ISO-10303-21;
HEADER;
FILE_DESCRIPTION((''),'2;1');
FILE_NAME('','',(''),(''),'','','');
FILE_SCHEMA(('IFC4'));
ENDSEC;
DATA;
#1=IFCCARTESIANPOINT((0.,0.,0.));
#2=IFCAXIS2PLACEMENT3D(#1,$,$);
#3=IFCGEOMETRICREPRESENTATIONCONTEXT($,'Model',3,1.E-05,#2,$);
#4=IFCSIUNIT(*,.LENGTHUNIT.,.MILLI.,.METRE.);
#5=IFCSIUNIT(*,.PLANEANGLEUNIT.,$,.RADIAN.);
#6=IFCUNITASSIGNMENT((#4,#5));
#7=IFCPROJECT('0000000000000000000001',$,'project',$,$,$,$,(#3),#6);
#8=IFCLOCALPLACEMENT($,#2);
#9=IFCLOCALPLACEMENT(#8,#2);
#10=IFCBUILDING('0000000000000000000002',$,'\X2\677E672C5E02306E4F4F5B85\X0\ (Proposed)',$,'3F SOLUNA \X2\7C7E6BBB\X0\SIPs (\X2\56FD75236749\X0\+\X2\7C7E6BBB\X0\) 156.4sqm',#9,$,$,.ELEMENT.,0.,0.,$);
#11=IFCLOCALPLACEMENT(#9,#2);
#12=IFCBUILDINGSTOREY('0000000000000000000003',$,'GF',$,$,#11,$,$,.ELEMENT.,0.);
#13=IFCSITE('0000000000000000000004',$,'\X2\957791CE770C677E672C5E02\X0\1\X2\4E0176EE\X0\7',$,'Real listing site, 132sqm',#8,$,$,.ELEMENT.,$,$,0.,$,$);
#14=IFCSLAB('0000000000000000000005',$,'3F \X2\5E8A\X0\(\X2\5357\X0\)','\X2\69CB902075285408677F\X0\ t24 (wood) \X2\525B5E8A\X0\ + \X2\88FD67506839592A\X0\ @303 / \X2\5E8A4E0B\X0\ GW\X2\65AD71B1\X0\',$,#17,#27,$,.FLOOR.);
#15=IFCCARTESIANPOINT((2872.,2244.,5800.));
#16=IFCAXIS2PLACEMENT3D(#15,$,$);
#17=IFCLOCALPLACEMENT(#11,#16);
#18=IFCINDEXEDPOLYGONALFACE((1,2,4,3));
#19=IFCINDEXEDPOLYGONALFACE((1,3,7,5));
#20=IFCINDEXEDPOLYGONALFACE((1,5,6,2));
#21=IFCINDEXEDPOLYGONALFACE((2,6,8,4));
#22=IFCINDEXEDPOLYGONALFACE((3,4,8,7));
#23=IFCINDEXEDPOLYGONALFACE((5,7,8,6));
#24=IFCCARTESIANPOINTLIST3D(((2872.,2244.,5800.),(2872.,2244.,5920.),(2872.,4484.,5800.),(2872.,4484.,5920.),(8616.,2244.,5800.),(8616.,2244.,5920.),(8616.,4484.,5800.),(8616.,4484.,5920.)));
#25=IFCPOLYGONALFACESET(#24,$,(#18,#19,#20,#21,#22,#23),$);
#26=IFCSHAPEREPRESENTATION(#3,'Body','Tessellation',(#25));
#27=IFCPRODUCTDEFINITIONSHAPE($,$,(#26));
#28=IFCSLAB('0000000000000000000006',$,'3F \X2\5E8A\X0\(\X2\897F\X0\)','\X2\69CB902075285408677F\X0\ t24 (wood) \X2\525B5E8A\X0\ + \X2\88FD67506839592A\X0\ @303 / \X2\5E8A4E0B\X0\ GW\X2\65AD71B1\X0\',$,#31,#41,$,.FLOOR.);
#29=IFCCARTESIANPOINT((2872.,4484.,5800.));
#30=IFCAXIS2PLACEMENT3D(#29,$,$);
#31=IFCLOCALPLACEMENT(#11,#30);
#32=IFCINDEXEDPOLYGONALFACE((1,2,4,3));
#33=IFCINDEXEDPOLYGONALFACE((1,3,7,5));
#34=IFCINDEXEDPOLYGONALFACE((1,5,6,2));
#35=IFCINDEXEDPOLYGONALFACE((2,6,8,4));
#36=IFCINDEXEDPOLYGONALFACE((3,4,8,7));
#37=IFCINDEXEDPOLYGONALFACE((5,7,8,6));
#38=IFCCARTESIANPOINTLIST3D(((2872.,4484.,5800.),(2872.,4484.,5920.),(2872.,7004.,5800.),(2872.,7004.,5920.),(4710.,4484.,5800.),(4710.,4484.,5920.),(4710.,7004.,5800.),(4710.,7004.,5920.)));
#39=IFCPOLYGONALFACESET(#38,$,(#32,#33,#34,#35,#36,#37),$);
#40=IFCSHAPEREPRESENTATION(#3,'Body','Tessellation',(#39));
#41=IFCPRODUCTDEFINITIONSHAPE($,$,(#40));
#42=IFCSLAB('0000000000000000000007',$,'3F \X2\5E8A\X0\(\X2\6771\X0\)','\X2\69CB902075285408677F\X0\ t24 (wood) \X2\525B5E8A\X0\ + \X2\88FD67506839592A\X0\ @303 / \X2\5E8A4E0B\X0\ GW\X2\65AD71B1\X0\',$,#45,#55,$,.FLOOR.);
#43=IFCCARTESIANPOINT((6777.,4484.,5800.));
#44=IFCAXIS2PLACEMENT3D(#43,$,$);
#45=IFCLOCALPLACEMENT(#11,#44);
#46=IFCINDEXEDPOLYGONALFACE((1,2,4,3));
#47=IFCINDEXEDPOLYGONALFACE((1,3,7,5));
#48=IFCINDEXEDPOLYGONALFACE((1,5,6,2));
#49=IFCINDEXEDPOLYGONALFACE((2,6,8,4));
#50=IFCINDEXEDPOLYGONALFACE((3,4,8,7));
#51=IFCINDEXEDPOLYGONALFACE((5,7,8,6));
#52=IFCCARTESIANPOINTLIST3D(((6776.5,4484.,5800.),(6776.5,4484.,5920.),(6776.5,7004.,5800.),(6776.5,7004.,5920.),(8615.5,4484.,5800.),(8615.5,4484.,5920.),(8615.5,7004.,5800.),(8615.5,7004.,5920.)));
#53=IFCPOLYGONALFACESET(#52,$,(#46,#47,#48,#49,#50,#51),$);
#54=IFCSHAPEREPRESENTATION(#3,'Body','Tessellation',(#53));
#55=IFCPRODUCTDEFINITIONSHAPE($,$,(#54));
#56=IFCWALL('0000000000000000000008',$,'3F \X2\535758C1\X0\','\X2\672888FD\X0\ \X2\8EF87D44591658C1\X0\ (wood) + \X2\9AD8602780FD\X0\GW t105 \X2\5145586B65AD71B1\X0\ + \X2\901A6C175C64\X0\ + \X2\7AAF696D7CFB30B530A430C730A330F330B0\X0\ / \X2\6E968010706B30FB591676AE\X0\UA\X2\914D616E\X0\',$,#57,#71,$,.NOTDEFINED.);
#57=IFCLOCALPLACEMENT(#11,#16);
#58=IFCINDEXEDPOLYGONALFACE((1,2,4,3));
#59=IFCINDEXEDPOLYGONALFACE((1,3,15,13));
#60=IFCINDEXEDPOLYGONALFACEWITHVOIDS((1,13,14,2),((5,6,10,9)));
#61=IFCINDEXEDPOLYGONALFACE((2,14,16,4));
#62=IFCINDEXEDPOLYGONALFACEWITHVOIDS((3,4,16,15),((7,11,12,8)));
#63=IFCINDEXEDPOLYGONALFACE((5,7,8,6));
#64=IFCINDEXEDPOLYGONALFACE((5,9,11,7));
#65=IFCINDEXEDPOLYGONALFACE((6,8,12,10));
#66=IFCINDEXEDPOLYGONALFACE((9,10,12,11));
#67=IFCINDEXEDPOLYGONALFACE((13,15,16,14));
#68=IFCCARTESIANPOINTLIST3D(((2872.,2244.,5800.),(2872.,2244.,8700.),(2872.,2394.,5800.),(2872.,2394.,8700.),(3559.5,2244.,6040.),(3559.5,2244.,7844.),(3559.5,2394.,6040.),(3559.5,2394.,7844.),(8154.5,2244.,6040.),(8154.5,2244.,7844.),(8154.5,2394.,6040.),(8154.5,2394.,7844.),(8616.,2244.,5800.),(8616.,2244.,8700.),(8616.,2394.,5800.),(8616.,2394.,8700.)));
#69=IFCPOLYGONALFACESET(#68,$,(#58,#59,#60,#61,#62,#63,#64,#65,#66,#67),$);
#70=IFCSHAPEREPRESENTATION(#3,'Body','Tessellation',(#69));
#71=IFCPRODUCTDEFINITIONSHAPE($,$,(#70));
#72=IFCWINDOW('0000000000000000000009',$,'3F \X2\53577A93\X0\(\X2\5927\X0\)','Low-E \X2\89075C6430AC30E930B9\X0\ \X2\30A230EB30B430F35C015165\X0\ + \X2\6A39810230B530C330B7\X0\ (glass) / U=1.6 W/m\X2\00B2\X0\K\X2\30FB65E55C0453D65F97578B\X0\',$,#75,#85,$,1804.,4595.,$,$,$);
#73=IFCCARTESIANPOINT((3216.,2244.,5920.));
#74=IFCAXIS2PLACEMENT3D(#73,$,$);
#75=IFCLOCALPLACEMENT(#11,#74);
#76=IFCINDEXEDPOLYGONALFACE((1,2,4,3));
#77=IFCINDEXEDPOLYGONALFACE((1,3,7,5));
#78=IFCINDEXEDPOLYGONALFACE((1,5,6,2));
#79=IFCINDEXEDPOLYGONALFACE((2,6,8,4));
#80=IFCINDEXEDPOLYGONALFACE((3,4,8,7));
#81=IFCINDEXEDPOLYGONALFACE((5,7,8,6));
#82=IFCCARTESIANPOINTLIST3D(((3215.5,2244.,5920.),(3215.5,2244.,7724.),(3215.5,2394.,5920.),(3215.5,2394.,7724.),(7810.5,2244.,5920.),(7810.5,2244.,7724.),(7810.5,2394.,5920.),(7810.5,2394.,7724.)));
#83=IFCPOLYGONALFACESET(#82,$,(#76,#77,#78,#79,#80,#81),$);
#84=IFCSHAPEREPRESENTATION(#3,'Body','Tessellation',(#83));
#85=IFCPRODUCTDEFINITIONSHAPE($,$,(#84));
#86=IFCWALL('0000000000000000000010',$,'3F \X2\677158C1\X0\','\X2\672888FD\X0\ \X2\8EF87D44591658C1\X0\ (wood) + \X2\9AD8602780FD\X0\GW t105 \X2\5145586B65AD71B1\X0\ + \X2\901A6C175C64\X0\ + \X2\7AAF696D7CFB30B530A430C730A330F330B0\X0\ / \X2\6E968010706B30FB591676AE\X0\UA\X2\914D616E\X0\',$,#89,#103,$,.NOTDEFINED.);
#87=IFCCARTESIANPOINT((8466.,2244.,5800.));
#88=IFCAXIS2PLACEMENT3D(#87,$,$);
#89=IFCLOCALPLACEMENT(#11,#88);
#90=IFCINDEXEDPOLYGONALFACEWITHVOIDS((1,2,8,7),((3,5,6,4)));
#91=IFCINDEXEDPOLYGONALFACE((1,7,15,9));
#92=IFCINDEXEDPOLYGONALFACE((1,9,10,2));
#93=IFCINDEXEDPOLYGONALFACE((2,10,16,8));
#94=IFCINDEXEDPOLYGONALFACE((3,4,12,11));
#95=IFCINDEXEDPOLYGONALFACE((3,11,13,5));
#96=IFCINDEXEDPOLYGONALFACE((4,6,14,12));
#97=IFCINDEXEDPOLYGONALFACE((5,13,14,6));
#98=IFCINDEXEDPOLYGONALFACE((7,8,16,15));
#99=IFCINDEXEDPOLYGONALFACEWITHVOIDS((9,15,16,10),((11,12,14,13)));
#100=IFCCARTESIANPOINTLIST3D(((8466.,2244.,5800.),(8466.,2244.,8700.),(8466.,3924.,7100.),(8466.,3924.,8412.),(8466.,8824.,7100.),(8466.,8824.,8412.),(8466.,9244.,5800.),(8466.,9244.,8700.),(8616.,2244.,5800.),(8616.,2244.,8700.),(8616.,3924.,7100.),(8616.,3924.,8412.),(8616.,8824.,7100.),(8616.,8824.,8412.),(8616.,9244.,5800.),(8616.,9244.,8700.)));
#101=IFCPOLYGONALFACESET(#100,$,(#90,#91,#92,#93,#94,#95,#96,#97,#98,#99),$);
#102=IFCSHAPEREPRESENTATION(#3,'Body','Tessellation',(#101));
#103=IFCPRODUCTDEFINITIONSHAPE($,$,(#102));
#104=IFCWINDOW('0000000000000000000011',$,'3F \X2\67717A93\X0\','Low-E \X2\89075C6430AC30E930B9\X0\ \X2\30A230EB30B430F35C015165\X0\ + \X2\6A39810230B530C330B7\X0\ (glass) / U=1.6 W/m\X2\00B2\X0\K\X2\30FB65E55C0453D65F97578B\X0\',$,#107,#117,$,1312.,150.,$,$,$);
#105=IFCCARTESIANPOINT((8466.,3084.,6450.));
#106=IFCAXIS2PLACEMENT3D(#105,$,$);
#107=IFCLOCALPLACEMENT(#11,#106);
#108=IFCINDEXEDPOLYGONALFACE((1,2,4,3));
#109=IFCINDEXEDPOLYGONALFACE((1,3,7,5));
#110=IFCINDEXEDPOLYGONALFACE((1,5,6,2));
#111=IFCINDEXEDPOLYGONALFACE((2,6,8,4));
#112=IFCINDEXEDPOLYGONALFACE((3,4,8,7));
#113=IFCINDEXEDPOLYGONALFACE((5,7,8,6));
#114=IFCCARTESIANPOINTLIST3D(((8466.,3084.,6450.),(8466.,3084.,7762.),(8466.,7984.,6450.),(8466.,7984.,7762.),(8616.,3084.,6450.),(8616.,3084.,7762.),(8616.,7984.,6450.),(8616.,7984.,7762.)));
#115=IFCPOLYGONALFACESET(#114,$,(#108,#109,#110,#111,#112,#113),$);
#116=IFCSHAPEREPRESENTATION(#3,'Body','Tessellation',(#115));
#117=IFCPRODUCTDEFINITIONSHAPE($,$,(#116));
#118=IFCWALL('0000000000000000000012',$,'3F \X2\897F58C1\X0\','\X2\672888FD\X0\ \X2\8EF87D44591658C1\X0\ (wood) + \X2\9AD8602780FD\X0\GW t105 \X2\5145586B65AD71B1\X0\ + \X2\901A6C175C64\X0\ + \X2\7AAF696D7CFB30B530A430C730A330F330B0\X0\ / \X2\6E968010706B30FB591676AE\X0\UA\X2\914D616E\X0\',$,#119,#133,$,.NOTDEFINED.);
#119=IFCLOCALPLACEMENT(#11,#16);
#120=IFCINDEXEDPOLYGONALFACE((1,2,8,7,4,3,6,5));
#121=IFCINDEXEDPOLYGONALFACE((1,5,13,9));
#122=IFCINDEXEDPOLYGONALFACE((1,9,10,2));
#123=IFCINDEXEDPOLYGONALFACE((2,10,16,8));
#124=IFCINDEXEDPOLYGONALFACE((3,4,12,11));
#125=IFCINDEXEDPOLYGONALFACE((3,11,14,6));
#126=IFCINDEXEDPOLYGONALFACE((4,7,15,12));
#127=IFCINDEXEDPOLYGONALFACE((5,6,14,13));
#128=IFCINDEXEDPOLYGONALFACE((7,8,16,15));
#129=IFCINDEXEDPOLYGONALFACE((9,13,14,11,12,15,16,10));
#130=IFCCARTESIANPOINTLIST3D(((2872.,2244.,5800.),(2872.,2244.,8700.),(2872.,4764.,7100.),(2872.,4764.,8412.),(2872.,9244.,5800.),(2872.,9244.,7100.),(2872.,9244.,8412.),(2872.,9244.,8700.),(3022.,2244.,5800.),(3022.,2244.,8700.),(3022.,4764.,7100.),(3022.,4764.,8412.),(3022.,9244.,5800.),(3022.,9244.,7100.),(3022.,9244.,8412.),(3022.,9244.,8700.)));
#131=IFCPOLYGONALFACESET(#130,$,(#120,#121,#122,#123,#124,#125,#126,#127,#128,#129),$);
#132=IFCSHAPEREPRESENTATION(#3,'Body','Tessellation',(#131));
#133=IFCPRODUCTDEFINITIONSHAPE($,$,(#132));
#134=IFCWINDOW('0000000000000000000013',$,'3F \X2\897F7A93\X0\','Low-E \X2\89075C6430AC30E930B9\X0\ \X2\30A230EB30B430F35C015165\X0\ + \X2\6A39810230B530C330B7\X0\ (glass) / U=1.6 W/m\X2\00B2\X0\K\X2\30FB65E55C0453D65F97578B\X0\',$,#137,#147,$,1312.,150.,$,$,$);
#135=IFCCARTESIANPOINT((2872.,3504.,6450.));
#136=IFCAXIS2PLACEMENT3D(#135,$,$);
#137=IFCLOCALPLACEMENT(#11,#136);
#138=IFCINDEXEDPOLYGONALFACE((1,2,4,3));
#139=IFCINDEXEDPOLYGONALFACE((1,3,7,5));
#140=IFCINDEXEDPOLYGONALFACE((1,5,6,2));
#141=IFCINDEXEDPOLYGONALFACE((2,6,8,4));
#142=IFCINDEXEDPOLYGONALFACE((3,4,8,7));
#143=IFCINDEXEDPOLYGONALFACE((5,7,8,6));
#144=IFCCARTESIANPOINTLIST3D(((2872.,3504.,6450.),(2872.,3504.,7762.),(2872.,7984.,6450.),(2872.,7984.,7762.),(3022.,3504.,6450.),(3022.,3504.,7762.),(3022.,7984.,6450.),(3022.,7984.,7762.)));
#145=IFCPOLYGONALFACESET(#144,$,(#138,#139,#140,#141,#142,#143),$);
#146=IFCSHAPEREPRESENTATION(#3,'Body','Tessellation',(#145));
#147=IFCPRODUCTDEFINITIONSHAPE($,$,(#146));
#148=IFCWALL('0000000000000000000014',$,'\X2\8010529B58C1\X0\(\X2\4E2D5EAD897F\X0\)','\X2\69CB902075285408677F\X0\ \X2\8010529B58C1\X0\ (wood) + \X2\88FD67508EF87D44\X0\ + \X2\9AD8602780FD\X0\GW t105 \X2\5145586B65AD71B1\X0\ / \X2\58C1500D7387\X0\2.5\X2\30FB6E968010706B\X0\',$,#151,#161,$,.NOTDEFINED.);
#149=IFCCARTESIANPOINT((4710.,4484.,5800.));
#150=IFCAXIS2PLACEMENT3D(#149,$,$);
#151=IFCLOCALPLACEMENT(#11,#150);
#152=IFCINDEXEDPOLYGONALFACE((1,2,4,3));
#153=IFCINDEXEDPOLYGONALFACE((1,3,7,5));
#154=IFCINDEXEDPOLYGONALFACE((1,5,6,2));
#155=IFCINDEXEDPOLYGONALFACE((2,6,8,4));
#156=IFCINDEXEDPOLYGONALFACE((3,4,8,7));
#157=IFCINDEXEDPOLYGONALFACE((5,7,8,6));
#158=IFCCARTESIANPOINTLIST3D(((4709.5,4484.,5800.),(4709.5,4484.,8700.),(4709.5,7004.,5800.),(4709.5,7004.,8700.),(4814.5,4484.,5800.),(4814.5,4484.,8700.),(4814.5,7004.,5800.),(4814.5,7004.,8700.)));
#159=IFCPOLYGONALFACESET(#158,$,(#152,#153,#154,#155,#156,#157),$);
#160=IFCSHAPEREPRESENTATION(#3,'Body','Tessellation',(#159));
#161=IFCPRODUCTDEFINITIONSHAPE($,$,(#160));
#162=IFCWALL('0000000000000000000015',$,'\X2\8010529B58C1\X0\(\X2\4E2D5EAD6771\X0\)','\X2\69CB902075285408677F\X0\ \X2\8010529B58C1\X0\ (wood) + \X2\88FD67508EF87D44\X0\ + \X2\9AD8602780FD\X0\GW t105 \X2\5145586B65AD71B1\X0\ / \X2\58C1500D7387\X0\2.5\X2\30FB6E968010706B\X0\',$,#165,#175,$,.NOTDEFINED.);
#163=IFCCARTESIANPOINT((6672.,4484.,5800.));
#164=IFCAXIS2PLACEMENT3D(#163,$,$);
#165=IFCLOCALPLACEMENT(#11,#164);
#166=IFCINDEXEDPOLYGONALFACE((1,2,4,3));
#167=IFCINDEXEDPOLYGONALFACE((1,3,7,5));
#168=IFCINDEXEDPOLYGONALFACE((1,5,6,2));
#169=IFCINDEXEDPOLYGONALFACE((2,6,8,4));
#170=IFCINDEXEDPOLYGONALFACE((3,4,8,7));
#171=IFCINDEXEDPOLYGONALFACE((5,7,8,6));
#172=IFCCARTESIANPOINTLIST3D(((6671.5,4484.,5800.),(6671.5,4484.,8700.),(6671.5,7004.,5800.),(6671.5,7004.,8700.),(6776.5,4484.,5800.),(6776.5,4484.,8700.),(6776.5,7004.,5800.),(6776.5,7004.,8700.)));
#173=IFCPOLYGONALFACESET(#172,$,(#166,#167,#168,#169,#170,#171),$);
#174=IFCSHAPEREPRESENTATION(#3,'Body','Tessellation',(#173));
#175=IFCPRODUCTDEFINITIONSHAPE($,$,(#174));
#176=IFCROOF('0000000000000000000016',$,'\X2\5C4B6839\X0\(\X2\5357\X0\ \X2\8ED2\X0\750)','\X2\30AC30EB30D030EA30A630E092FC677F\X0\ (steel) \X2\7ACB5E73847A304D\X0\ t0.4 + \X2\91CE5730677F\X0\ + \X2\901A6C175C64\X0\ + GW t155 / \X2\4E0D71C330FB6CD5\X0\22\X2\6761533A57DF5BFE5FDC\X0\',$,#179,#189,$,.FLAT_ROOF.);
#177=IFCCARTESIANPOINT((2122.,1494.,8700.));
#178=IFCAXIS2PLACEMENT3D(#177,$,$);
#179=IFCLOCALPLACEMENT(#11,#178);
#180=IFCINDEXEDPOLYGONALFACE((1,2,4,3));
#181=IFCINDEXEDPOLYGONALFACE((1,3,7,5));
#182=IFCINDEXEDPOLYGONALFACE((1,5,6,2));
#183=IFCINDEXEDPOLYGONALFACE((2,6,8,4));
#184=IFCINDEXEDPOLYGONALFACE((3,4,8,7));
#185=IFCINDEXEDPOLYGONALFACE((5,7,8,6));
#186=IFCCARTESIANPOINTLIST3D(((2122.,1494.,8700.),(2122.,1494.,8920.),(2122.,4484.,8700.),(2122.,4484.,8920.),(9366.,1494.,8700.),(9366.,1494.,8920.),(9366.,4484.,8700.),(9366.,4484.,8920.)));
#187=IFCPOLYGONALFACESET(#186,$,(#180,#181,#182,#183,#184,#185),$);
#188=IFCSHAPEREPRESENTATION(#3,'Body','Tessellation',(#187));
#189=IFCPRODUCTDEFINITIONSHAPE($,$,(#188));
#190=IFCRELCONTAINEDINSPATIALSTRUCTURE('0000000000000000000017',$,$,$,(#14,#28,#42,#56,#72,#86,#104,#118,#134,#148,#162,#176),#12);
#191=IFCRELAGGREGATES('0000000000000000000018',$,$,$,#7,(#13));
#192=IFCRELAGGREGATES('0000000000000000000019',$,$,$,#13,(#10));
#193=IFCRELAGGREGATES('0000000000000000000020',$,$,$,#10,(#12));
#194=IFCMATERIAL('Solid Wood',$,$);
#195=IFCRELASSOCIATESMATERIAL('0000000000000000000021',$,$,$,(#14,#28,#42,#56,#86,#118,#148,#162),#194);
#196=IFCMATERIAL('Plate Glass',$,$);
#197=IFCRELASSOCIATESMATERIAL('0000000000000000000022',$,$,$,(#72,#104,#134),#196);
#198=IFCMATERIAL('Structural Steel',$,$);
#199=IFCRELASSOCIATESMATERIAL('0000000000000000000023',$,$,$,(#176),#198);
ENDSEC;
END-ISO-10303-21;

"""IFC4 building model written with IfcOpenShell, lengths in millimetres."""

from ifc_helpers import new_model, si_unit, frame, frame_2d, origin, place, context, project, spatial, rectangle, extrude, material, element, fill, save


model = new_model("IFC4")

# Units and contexts
model_context = context("Model", 3, precision=1e-05, world=origin())
ifc_project = project(units=[si_unit("LENGTHUNIT", "METRE", prefix="MILLI"), si_unit("PLANEANGLEUNIT", "RADIAN")], contexts=[model_context])

# Site, building, storey
site_placement = place(None, origin())
site = spatial("IfcSite", under=ifc_project, at=site_placement, Name="長野県松本市1丁目7", ObjectType="Real listing site, 132sqm", CompositionType="ELEMENT", RefElevation=0.0)
building_placement = place(site_placement, origin())
building = spatial("IfcBuilding", under=site, at=building_placement, Name="松本市の住宅 (Proposed)", ObjectType="3F SOLUNA 籾殻SIPs (国産杉+籾殻) 156.4sqm", CompositionType="ELEMENT", ElevationOfRefHeight=0.0, ElevationOfTerrain=0.0)
storey_placement = place(building_placement, origin())
storey = spatial("IfcBuildingStorey", under=building, at=storey_placement, Name="GF", CompositionType="ELEMENT", Elevation=0.0)

# Slabs
ifc_material_1 = material(Name="Solid Wood")
slab_1_placement = place(storey_placement, frame((2872.0, 2244.0, 5800.0)))
element("IfcSlab", 1, at=slab_1_placement, inside=storey, material=ifc_material_1, Name="3F 床(南)", Description="構造用合板 t24 (wood) 剛床 + 製材根太 @303 / 床下 GW断熱", PredefinedType="FLOOR", context=model_context, shape_type="SweptSolid", body=[
    extrude(rectangle(XDim=5744.0, YDim=2240.0, at=frame_2d((2872.0, 1120.0))), frame((2872.0, 2244.0, 5800.0)), (0.0, 0.0, 1.0), 120.0),
])
slab_2_placement = place(storey_placement, frame((2872.0, 4484.0, 5800.0)))
element("IfcSlab", 2, at=slab_2_placement, inside=storey, material=ifc_material_1, Name="3F 床(西)", Description="構造用合板 t24 (wood) 剛床 + 製材根太 @303 / 床下 GW断熱", PredefinedType="FLOOR", context=model_context, shape_type="SweptSolid", body=[
    extrude(rectangle(XDim=1838.0, YDim=2520.0, at=frame_2d((919.0, 1260.0))), frame((2872.0, 4484.0, 5800.0)), (0.0, 0.0, 1.0), 120.0),
])
slab_3_placement = place(storey_placement, frame((6777.0, 4484.0, 5800.0)))
element("IfcSlab", 3, at=slab_3_placement, inside=storey, material=ifc_material_1, Name="3F 床(東)", Description="構造用合板 t24 (wood) 剛床 + 製材根太 @303 / 床下 GW断熱", PredefinedType="FLOOR", context=model_context, shape_type="SweptSolid", body=[
    extrude(rectangle(XDim=1839.0, YDim=2520.0, at=frame_2d((919.0, 1260.0))), frame((6777.0, 4484.0, 5800.0)), (0.0, 0.0, 1.0), 120.0),
])

# Walls, openings, windows
wall_1_placement = place(storey_placement, frame((2872.0, 2244.0, 5800.0)))
wall_1 = element("IfcWall", 4, at=wall_1_placement, inside=storey, material=ifc_material_1, Name="3F 南壁", Description="木製 軸組外壁 (wood) + 高性能GW t105 充填断熱 + 通気層 + 窯業系サイディング / 準耐火・外皮UA配慮", PredefinedType="NOTDEFINED", context=model_context, shape_type="SweptSolid", body=[
    extrude(rectangle(XDim=5744.0, YDim=150.0, at=frame_2d((2872.0, 75.0))), frame((2872.0, 2244.0, 5800.0)), (0.0, 0.0, 1.0), 2900.0),
])
opening_1_placement = place(storey_placement, frame((3216.0, 2244.0, 5920.0)))
opening_1 = element("IfcOpeningElement", 5, at=opening_1_placement, cuts=wall_1, PredefinedType="NOTDEFINED", context=model_context, shape_type="SweptSolid", body=[
    extrude(rectangle(XDim=4595.0, YDim=150.0, at=frame_2d((2297.0, 75.0))), frame((3216.0, 2244.0, 5920.0)), (0.0, 0.0, 1.0), 1804.0),
])
ifc_material_2 = material(Name="Plate Glass")
window_1_placement = place(storey_placement, frame((3216.0, 2244.0, 5920.0)))
window_1 = element("IfcWindow", 6, at=window_1_placement, inside=storey, material=ifc_material_2, Name="3F 南窓(大)", Description="Low-E 複層ガラス アルゴン封入 + 樹脂サッシ (glass) / U=1.6 W/m²K・日射取得型", OverallHeight=1804.0, OverallWidth=4595.0, context=model_context, shape_type="SweptSolid", body=[
    extrude(rectangle(XDim=4595.0, YDim=150.0, at=frame_2d((2297.0, 75.0))), frame((3216.0, 2244.0, 5920.0)), (0.0, 0.0, 1.0), 1804.0),
])
fill(opening_1, window_1)
wall_2_placement = place(storey_placement, frame((8466.0, 2244.0, 5800.0)))
wall_2 = element("IfcWall", 7, at=wall_2_placement, inside=storey, material=ifc_material_1, Name="3F 東壁", Description="木製 軸組外壁 (wood) + 高性能GW t105 充填断熱 + 通気層 + 窯業系サイディング / 準耐火・外皮UA配慮", PredefinedType="NOTDEFINED", context=model_context, shape_type="SweptSolid", body=[
    extrude(rectangle(XDim=150.0, YDim=7000.0, at=frame_2d((75.0, 3500.0))), frame((8466.0, 2244.0, 5800.0)), (0.0, 0.0, 1.0), 2900.0),
])
opening_2_placement = place(storey_placement, frame((8466.0, 3084.0, 6450.0)))
opening_2 = element("IfcOpeningElement", 8, at=opening_2_placement, cuts=wall_2, PredefinedType="NOTDEFINED", context=model_context, shape_type="SweptSolid", body=[
    extrude(rectangle(XDim=150.0, YDim=4900.0, at=frame_2d((75.0, 2450.0))), frame((8466.0, 3084.0, 6450.0)), (0.0, 0.0, 1.0), 1312.0),
])
window_2_placement = place(storey_placement, frame((8466.0, 3084.0, 6450.0)))
window_2 = element("IfcWindow", 9, at=window_2_placement, inside=storey, material=ifc_material_2, Name="3F 東窓", Description="Low-E 複層ガラス アルゴン封入 + 樹脂サッシ (glass) / U=1.6 W/m²K・日射取得型", OverallHeight=1312.0, OverallWidth=150.0, context=model_context, shape_type="SweptSolid", body=[
    extrude(rectangle(XDim=150.0, YDim=4900.0, at=frame_2d((75.0, 2450.0))), frame((8466.0, 3084.0, 6450.0)), (0.0, 0.0, 1.0), 1312.0),
])
fill(opening_2, window_2)
wall_3_placement = place(storey_placement, frame((2872.0, 2244.0, 5800.0)))
wall_3 = element("IfcWall", 10, at=wall_3_placement, inside=storey, material=ifc_material_1, Name="3F 西壁", Description="木製 軸組外壁 (wood) + 高性能GW t105 充填断熱 + 通気層 + 窯業系サイディング / 準耐火・外皮UA配慮", PredefinedType="NOTDEFINED", context=model_context, shape_type="SweptSolid", body=[
    extrude(rectangle(XDim=150.0, YDim=7000.0, at=frame_2d((75.0, 3500.0))), frame((2872.0, 2244.0, 5800.0)), (0.0, 0.0, 1.0), 2900.0),
])
opening_3_placement = place(storey_placement, frame((2872.0, 3504.0, 6450.0)))
opening_3 = element("IfcOpeningElement", 11, at=opening_3_placement, cuts=wall_3, PredefinedType="NOTDEFINED", context=model_context, shape_type="SweptSolid", body=[
    extrude(rectangle(XDim=150.0, YDim=4480.0, at=frame_2d((75.0, 2240.0))), frame((2872.0, 3504.0, 6450.0)), (0.0, 0.0, 1.0), 1312.0),
])
window_3_placement = place(storey_placement, frame((2872.0, 3504.0, 6450.0)))
window_3 = element("IfcWindow", 12, at=window_3_placement, inside=storey, material=ifc_material_2, Name="3F 西窓", Description="Low-E 複層ガラス アルゴン封入 + 樹脂サッシ (glass) / U=1.6 W/m²K・日射取得型", OverallHeight=1312.0, OverallWidth=150.0, context=model_context, shape_type="SweptSolid", body=[
    extrude(rectangle(XDim=150.0, YDim=4480.0, at=frame_2d((75.0, 2240.0))), frame((2872.0, 3504.0, 6450.0)), (0.0, 0.0, 1.0), 1312.0),
])
fill(opening_3, window_3)

# Walls
wall_4_placement = place(storey_placement, frame((4710.0, 4484.0, 5800.0)))
element("IfcWall", 13, at=wall_4_placement, inside=storey, material=ifc_material_1, Name="耐力壁(中庭西)", Description="構造用合板 耐力壁 (wood) + 製材軸組 + 高性能GW t105 充填断熱 / 壁倍率2.5・準耐火", PredefinedType="NOTDEFINED", context=model_context, shape_type="SweptSolid", body=[
    extrude(rectangle(XDim=105.0, YDim=2520.0, at=frame_2d((52.0, 1260.0))), frame((4710.0, 4484.0, 5800.0)), (0.0, 0.0, 1.0), 2900.0),
])
wall_5_placement = place(storey_placement, frame((6672.0, 4484.0, 5800.0)))
element("IfcWall", 14, at=wall_5_placement, inside=storey, material=ifc_material_1, Name="耐力壁(中庭東)", Description="構造用合板 耐力壁 (wood) + 製材軸組 + 高性能GW t105 充填断熱 / 壁倍率2.5・準耐火", PredefinedType="NOTDEFINED", context=model_context, shape_type="SweptSolid", body=[
    extrude(rectangle(XDim=105.0, YDim=2520.0, at=frame_2d((52.0, 1260.0))), frame((6672.0, 4484.0, 5800.0)), (0.0, 0.0, 1.0), 2900.0),
])

# Roof
ifc_material_3 = material(Name="Structural Steel")
roof_1_placement = place(storey_placement, frame((2122.0, 1494.0, 8700.0)))
element("IfcRoof", 15, at=roof_1_placement, inside=storey, material=ifc_material_3, Name="屋根(南 軒750)", Description="ガルバリウム鋼板 (steel) 立平葺き t0.4 + 野地板 + 通気層 + GW t155 / 不燃・法22条区域対応", PredefinedType="FLAT_ROOF", context=model_context, shape_type="SweptSolid", body=[
    extrude(rectangle(XDim=7244.0, YDim=2990.0, at=frame_2d((3622.0, 1495.0))), frame((2122.0, 1494.0, 8700.0)), (0.0, 0.0, 1.0), 220.0),
])

save(model, "model.ifc")
